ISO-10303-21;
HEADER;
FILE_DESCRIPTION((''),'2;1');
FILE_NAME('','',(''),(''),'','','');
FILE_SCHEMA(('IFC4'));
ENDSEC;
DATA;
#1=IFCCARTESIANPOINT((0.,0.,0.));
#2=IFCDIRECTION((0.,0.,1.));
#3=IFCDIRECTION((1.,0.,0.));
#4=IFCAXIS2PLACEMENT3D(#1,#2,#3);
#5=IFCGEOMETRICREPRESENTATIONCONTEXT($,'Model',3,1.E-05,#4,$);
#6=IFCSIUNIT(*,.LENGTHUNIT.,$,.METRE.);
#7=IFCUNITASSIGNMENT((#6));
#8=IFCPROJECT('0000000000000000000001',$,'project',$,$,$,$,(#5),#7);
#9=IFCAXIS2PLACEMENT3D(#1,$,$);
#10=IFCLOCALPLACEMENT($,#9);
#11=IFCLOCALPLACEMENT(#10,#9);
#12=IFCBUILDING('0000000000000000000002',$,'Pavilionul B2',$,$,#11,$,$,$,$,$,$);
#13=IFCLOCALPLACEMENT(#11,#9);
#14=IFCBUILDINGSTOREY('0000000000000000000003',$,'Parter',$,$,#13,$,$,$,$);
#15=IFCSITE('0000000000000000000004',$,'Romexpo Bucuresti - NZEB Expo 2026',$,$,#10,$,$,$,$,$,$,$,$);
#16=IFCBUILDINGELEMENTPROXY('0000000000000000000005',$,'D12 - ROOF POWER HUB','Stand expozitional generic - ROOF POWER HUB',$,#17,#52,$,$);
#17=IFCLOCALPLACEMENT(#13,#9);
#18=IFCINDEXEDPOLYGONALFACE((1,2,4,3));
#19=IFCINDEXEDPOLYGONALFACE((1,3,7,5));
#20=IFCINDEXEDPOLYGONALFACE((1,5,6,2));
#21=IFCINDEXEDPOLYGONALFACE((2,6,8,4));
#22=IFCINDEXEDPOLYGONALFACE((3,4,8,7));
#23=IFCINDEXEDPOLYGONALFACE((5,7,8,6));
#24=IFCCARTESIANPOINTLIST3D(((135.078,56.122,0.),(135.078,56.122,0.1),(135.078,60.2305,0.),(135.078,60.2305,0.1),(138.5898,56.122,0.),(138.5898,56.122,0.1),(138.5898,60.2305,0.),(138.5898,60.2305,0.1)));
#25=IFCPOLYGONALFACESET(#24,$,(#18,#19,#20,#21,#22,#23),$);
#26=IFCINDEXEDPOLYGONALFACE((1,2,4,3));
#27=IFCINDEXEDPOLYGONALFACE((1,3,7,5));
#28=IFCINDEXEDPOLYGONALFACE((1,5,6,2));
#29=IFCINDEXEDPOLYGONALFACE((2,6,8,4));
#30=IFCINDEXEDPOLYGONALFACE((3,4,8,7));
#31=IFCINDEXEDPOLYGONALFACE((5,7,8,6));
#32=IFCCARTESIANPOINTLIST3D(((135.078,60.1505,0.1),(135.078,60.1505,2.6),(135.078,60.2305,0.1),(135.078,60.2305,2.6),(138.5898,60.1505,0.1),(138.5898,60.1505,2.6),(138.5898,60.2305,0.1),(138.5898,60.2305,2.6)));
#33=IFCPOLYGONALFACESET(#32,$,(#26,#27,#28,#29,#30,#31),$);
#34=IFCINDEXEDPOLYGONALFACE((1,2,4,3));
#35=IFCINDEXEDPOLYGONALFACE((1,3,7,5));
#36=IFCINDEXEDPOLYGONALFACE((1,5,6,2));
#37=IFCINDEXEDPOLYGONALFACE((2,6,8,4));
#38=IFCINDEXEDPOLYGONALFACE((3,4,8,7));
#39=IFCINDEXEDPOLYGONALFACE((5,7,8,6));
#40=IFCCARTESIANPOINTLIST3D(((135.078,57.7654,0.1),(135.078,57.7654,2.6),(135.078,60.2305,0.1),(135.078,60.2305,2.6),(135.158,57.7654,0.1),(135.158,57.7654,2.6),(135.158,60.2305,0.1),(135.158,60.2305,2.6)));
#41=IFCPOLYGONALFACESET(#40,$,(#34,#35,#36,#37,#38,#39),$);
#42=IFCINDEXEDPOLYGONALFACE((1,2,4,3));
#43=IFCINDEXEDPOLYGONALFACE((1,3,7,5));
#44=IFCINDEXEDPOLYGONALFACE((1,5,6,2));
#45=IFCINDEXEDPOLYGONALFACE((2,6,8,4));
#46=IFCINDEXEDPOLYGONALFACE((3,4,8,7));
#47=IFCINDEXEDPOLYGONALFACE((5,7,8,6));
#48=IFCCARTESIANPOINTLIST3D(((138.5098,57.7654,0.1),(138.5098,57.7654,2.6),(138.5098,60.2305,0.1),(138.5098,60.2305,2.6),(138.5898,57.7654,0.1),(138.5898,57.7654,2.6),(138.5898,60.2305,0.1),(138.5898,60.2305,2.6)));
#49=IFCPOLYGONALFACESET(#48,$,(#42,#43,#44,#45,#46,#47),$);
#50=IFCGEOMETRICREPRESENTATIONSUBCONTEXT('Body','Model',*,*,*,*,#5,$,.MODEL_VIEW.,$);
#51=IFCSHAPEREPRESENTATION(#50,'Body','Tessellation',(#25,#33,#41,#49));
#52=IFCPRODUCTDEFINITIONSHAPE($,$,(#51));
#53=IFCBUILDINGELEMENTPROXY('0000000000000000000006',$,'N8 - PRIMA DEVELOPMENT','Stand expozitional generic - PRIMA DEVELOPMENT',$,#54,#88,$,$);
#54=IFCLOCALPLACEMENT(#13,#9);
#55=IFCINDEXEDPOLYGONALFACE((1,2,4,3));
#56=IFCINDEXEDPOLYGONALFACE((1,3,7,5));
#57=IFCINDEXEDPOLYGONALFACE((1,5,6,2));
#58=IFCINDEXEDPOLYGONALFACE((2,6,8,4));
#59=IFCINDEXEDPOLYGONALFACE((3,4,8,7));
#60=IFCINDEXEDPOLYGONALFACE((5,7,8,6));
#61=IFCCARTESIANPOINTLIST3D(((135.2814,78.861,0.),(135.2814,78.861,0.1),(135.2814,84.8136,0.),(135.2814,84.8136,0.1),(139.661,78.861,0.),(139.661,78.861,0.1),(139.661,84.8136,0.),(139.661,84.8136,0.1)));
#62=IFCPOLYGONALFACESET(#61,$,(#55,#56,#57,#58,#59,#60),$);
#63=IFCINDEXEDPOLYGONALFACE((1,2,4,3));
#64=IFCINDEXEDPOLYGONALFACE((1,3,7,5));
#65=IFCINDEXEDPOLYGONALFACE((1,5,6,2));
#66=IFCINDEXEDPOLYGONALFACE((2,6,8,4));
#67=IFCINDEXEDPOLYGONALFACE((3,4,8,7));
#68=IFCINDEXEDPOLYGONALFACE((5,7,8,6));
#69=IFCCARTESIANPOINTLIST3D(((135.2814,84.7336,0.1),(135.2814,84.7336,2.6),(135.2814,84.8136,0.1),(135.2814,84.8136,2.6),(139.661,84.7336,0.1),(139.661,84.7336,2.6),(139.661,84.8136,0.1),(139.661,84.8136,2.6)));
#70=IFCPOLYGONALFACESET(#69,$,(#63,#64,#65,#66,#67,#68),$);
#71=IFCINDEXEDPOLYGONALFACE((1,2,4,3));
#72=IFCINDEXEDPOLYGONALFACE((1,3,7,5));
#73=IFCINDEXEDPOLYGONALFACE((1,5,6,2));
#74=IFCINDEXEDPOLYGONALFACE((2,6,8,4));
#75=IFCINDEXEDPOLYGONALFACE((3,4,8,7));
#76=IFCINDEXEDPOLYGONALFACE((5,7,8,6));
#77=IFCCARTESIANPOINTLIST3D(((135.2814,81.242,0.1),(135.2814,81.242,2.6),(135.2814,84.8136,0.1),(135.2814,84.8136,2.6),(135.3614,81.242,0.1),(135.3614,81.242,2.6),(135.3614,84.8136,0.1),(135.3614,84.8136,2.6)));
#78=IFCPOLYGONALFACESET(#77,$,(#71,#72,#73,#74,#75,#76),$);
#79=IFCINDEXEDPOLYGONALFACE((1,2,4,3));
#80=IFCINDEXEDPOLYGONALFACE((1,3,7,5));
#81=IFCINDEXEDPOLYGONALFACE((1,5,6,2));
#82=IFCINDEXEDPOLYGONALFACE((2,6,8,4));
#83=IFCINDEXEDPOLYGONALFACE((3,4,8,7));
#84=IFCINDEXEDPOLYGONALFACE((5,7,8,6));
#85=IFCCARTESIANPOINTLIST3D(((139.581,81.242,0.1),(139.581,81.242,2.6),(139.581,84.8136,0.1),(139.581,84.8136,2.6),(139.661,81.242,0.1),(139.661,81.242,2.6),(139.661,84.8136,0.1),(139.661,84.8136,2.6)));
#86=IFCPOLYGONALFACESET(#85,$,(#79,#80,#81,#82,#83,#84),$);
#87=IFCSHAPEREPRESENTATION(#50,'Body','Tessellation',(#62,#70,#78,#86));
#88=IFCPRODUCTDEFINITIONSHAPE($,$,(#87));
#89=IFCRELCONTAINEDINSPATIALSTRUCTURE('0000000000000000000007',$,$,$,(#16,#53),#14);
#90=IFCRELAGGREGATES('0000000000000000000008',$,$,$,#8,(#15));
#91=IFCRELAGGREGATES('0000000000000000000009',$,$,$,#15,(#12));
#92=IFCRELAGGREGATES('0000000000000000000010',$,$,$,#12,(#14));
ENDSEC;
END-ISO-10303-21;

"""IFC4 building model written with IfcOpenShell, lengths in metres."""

from ifc_helpers import new_model, si_unit, frame, frame_2d, origin, origin_with_axes, place, context, subcontext, project, spatial, rectangle, extrude, element, save


model = new_model("IFC4")

# Units and contexts
model_context = context("Model", 3, precision=1e-05, world=origin_with_axes())
body_context = subcontext(model_context, "Body", "Model", "MODEL_VIEW")
ifc_project = project(units=[si_unit("LENGTHUNIT", "METRE")], contexts=[model_context])

# Site, building, storey
site_placement = place(None, origin())
site = spatial("IfcSite", under=ifc_project, at=site_placement, Name="Romexpo Bucuresti - NZEB Expo 2026")
building_placement = place(site_placement, origin())
building = spatial("IfcBuilding", under=site, at=building_placement, Name="Pavilionul B2")
storey_placement = place(building_placement, origin())
storey = spatial("IfcBuildingStorey", under=building, at=storey_placement, Name="Parter")

# Building element proxies
proxy_1_placement = place(storey_placement, frame((135.078, 56.122, 0.0), z_axis=(0.0, 0.0, 1.0), x_axis=(1.0, 0.0, 0.0)))
element("IfcBuildingElementProxy", 1, at=proxy_1_placement, inside=storey, Name="D12 - ROOF POWER HUB", Description="Stand expozitional generic - ROOF POWER HUB", context=body_context, shape_type="SweptSolid", body=[
    extrude(rectangle(XDim=3.5119, YDim=4.1085, at=frame_2d((1.7559, 2.0542))), origin(), (0.0, 0.0, 1.0), 0.1),
    extrude(rectangle(XDim=3.5119, YDim=0.08, at=frame_2d((1.7559, 4.0685))), frame((0.0, 0.0, 0.1)), (0.0, 0.0, 1.0), 2.5),
    extrude(rectangle(XDim=0.08, YDim=2.4651, at=frame_2d((0.04, 2.8759))), frame((0.0, 0.0, 0.1)), (0.0, 0.0, 1.0), 2.5),
    extrude(rectangle(XDim=0.08, YDim=2.4651, at=frame_2d((3.4719, 2.8759))), frame((0.0, 0.0, 0.1)), (0.0, 0.0, 1.0), 2.5),
])
proxy_2_placement = place(storey_placement, frame((135.2814, 78.861, 0.0), z_axis=(0.0, 0.0, 1.0), x_axis=(1.0, 0.0, 0.0)))
element("IfcBuildingElementProxy", 2, at=proxy_2_placement, inside=storey, Name="N8 - PRIMA DEVELOPMENT", Description="Stand expozitional generic - PRIMA DEVELOPMENT", context=body_context, shape_type="SweptSolid", body=[
    extrude(rectangle(XDim=4.3797, YDim=5.9525, at=frame_2d((2.1898, 2.9763))), origin(), (0.0, 0.0, 1.0), 0.1),
    extrude(rectangle(XDim=4.3797, YDim=0.08, at=frame_2d((2.1898, 5.9125))), frame((0.0, 0.0, 0.1)), (0.0, 0.0, 1.0), 2.5),
    extrude(rectangle(XDim=0.08, YDim=3.5715, at=frame_2d((0.04, 4.1668))), frame((0.0, 0.0, 0.1)), (0.0, 0.0, 1.0), 2.5),
    extrude(rectangle(XDim=0.08, YDim=3.5715, at=frame_2d((4.3397, 4.1668))), frame((0.0, 0.0, 0.1)), (0.0, 0.0, 1.0), 2.5),
])

save(model, "model.ifc")
